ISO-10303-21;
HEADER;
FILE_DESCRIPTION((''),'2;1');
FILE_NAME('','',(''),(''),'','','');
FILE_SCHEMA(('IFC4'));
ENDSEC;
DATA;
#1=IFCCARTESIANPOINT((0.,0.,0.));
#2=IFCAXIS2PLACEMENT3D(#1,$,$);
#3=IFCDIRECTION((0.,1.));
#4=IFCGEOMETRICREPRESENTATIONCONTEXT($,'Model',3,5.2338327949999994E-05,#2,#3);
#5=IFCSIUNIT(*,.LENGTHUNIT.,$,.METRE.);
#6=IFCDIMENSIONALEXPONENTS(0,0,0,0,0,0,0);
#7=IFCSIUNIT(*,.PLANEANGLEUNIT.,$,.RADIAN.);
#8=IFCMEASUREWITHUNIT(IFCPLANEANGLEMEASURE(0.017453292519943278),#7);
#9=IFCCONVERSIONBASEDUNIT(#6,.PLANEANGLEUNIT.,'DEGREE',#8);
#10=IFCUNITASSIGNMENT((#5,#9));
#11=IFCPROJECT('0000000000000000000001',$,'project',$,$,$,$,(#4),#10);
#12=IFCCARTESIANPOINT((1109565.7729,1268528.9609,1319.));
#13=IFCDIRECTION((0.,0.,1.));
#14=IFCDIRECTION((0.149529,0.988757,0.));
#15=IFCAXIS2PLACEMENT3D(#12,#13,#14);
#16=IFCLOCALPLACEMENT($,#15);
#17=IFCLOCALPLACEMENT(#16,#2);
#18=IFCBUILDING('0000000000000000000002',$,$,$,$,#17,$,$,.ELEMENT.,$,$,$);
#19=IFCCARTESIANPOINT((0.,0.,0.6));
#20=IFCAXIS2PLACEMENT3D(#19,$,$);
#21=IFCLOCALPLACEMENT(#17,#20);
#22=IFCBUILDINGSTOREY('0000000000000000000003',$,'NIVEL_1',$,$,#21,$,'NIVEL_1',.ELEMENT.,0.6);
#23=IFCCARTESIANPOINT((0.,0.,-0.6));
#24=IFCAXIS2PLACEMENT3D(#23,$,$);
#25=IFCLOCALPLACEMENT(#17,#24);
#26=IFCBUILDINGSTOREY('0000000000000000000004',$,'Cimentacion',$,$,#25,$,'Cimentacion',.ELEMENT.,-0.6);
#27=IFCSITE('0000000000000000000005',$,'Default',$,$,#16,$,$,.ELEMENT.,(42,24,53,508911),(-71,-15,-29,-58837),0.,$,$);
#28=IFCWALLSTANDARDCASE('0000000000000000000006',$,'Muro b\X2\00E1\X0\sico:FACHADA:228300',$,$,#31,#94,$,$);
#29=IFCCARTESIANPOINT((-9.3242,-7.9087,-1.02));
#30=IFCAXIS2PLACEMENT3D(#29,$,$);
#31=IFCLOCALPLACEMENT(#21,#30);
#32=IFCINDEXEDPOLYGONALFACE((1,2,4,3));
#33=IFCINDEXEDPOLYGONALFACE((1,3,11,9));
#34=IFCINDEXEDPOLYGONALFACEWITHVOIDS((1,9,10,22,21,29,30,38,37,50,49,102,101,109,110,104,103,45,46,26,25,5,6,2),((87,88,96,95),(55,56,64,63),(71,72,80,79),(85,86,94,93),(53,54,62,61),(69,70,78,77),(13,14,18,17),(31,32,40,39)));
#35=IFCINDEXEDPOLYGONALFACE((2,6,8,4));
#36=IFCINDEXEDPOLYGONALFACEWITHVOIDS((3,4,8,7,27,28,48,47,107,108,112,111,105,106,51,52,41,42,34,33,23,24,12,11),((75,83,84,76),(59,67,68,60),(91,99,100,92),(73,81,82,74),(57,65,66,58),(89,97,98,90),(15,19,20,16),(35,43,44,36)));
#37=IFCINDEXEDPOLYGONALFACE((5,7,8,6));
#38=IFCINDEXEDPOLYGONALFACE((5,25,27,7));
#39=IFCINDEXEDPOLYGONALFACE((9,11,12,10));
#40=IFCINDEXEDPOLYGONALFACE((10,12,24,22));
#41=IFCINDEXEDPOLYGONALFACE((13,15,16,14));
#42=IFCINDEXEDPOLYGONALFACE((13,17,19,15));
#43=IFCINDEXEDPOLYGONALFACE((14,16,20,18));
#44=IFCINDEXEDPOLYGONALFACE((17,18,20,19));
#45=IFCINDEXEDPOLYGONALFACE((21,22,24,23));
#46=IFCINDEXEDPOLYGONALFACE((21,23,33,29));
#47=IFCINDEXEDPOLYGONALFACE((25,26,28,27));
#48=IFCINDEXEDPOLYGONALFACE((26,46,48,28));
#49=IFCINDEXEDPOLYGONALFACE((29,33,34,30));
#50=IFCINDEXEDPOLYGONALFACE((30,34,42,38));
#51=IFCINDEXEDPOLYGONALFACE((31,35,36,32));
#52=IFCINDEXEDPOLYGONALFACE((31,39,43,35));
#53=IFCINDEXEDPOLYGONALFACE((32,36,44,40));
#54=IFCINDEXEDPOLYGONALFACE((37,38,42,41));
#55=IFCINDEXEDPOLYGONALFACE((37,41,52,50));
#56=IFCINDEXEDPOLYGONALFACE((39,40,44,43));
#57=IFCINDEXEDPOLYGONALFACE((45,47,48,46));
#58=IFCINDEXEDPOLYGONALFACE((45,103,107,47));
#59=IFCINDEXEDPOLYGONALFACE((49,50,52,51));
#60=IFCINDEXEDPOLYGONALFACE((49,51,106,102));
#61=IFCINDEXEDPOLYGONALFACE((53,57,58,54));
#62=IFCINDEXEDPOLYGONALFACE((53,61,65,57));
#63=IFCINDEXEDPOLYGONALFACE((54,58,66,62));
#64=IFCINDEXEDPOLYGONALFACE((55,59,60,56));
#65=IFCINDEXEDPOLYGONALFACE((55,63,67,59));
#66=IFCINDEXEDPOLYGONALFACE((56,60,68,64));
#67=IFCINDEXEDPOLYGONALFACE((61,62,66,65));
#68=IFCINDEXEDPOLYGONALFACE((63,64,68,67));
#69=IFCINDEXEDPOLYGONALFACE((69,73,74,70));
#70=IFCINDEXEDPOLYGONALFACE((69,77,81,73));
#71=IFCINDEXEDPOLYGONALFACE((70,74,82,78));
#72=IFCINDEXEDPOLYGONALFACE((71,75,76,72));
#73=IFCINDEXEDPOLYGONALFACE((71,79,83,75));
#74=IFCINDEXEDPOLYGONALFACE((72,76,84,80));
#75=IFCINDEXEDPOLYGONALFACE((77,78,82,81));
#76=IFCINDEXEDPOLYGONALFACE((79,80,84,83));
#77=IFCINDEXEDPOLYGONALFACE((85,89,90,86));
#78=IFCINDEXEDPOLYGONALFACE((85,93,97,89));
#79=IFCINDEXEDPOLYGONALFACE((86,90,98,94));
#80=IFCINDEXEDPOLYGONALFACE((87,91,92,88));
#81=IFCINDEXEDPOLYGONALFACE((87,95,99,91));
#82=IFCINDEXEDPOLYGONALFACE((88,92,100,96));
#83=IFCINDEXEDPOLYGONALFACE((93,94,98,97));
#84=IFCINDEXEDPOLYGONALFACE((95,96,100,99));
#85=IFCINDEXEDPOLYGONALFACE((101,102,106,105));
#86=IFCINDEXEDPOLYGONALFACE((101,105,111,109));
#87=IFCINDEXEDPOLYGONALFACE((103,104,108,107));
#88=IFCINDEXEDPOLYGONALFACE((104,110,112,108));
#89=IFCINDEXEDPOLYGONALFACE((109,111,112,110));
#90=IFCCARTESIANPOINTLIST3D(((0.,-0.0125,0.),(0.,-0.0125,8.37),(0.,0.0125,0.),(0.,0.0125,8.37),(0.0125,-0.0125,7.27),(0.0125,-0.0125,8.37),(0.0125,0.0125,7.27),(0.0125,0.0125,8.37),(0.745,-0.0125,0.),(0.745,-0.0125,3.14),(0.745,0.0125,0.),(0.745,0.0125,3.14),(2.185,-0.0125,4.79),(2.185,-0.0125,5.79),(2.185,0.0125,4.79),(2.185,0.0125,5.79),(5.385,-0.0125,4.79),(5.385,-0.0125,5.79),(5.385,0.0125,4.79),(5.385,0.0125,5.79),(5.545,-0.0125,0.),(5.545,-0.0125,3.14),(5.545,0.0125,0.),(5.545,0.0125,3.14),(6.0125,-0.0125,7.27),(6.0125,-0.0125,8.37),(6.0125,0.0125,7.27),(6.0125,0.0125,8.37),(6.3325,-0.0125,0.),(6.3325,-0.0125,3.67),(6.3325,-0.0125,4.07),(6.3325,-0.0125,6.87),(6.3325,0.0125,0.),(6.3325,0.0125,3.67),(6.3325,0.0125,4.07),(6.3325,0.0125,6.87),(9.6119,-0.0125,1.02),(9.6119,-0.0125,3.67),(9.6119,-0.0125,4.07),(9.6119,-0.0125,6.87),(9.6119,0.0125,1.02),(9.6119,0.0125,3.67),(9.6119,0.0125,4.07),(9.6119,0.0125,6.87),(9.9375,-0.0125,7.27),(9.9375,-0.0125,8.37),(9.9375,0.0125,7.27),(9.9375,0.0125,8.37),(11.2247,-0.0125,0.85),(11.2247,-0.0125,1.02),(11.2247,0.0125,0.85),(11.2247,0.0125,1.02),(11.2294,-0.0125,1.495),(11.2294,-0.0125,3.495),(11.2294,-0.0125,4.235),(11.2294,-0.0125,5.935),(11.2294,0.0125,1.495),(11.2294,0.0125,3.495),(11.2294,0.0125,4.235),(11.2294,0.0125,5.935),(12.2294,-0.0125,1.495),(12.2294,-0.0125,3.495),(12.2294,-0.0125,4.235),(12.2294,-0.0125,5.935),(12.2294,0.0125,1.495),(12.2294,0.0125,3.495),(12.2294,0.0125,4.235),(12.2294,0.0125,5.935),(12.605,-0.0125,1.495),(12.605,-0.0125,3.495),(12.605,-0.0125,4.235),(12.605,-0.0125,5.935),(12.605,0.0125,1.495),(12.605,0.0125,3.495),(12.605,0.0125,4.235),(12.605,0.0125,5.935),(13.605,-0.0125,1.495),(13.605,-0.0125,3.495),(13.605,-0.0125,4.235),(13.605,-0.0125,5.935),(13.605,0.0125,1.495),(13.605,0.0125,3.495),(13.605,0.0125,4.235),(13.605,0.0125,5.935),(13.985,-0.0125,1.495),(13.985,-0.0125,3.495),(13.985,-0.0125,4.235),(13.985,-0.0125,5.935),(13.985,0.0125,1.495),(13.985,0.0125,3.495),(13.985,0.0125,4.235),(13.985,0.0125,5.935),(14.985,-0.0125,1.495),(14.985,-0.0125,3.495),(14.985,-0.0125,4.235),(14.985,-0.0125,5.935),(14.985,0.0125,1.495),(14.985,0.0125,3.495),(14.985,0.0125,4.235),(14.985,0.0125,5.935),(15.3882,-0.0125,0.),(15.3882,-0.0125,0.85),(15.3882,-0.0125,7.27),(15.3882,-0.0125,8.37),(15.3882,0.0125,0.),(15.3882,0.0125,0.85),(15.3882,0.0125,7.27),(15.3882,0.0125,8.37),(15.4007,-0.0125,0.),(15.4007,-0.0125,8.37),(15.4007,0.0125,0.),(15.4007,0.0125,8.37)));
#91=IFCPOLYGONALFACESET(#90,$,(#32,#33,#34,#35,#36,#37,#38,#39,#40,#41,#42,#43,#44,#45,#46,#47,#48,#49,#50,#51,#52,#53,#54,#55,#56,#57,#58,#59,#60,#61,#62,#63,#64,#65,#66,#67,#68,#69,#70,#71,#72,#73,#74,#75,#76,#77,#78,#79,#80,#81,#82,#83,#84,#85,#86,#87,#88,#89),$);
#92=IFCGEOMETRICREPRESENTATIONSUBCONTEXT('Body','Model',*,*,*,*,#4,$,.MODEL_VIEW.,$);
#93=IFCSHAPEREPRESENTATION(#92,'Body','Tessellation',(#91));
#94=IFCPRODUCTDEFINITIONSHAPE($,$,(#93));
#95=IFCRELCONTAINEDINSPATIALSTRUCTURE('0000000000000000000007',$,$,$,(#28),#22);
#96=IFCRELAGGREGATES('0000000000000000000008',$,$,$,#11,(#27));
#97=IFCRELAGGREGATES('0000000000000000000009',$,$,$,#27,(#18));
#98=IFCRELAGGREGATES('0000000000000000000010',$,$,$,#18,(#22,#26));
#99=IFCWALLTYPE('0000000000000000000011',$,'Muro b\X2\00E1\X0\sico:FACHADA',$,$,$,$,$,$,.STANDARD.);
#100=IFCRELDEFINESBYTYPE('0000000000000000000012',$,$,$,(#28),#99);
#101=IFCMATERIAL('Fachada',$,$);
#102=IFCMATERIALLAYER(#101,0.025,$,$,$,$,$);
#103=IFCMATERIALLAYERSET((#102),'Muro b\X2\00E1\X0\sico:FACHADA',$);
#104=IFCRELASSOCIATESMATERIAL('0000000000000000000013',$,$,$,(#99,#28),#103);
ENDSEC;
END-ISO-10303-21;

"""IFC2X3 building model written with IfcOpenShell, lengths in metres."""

from ifc_helpers import new_model, entity, si_unit, converted_unit, direction, frame, frame_2d, origin, origin_2d_with_axis, place, context, subcontext, project, spatial, polyline, rectangle, outline, extrude, material, layer, layer_set, layer_usage, type_object, element, save


model = new_model("IFC2X3")

# Units and contexts
model_context = context("Model", 3, precision=5.2338327949999994e-05, world=origin(), true_north=direction((0.0, 1.0)))
body_context = subcontext(model_context, "Body", "Model", "MODEL_VIEW")
ifc_project = project(units=[si_unit("LENGTHUNIT", "METRE"), converted_unit("PLANEANGLEUNIT", "DEGREE", entity("IfcPlaneAngleMeasure", 0.017453292519943278), si_unit("PLANEANGLEUNIT", "RADIAN"), dimensions=[0, 0, 0, 0, 0, 0, 0])], contexts=[model_context])

# Site, building, storey
site_placement = place(None, frame((1109565.7729, 1268528.9609, 1319.0), z_axis=(0.0, 0.0, 1.0), x_axis=(0.149529, 0.988757, 0.0)))
site = spatial("IfcSite", under=ifc_project, at=site_placement, Name="Default", CompositionType="ELEMENT", RefLatitude=(42, 24, 53, 508911), RefLongitude=(-71, -15, -29, -58837), RefElevation=0.0)
building_placement = place(site_placement, origin())
building = spatial("IfcBuilding", under=site, at=building_placement, CompositionType="ELEMENT")
storey_1_placement = place(building_placement, frame((0.0, 0.0, 0.6)))
storey_1 = spatial("IfcBuildingStorey", under=building, at=storey_1_placement, Name="NIVEL_1", LongName="NIVEL_1", CompositionType="ELEMENT", Elevation=0.6)

# Shared definitions
storey_2_placement = place(building_placement, frame((0.0, 0.0, -0.6)))
storey_2 = spatial("IfcBuildingStorey", under=building, at=storey_2_placement, Name="Cimentacion", LongName="Cimentacion", CompositionType="ELEMENT", Elevation=-0.6)

# Wall, openings
ifc_material_1 = material(Name="Fachada")
ifc_layer_1 = layer(ifc_material_1, 0.025)
ifc_layer_set_1 = layer_set([ifc_layer_1], Name="Muro básico:FACHADA")
ifc_layer_usage_1 = layer_usage(ifc_layer_set_1, "AXIS2", "POSITIVE", -0.0125)
wall_type_1 = type_object("IfcWallType", Name="Muro básico:FACHADA", PredefinedType="STANDARD", material=ifc_layer_set_1)
wall_1_placement = place(storey_1_placement, frame((-9.3242, -7.9087, -1.02)))
wall_1 = element("IfcWallStandardCase", 1, at=wall_1_placement, inside=storey_1, type_object=wall_type_1, material=ifc_layer_usage_1, Name="Muro básico:FACHADA:228300", context=body_context, shape_type="SweptSolid", body=[
    extrude(rectangle(XDim=15.4007, YDim=0.025, at=frame_2d((7.7004, 0.0), x_axis=(-1.0, 0.0))), origin(), (0.0, 0.0, 1.0), 8.37),
])
opening_1_placement = place(wall_1_placement, origin())
element("IfcOpeningElement", 2, at=opening_1_placement, cuts=wall_1, ObjectType="Opening", context=body_context, shape_type="SweptSolid", body=[
    extrude(rectangle(XDim=2.8, YDim=3.2794, at=frame_2d((0.0, 0.0), x_axis=(0.0, 1.0))), frame((7.9722, 0.0125, 5.47), z_axis=(0.0, -1.0, 0.0), x_axis=(-1.0, 0.0, 0.0)), (0.0, 0.0, 1.0), 0.025),
])
opening_2_placement = place(wall_1_placement, origin())
element("IfcOpeningElement", 3, at=opening_2_placement, cuts=wall_1, ObjectType="Opening", context=body_context, shape_type="SweptSolid", body=[
    extrude(rectangle(XDim=1.0, YDim=3.2, at=frame_2d((0.0, 0.0), x_axis=(0.0, 1.0))), frame((3.785, 0.0125, 5.29), z_axis=(0.0, -1.0, 0.0), x_axis=(-1.0, 0.0, 0.0)), (0.0, 0.0, 1.0), 0.025),
])
opening_3_placement = place(wall_1_placement, origin())
element("IfcOpeningElement", 4, at=opening_3_placement, cuts=wall_1, ObjectType="Opening", context=body_context, shape_type="SweptSolid", body=[
    extrude(rectangle(XDim=1.7, YDim=1.0, at=frame_2d((0.0, 0.0), x_axis=(0.0, 1.0))), frame((11.7294, 0.0125, 5.085), z_axis=(0.0, -1.0, 0.0), x_axis=(-1.0, 0.0, 0.0)), (0.0, 0.0, 1.0), 0.025),
])
opening_4_placement = place(wall_1_placement, origin())
element("IfcOpeningElement", 5, at=opening_4_placement, cuts=wall_1, ObjectType="Opening", context=body_context, shape_type="SweptSolid", body=[
    extrude(rectangle(XDim=1.7, YDim=1.0, at=origin_2d_with_axis()), frame((13.105, 0.0125, 5.085), z_axis=(0.0, -1.0, 0.0), x_axis=(0.0, 0.0, 1.0)), (0.0, 0.0, 1.0), 0.025),
])
opening_5_placement = place(wall_1_placement, origin())
element("IfcOpeningElement", 6, at=opening_5_placement, cuts=wall_1, ObjectType="Opening", context=body_context, shape_type="SweptSolid", body=[
    extrude(rectangle(XDim=1.7, YDim=1.0, at=origin_2d_with_axis()), frame((14.485, 0.0125, 5.085), z_axis=(0.0, -1.0, 0.0), x_axis=(0.0, 0.0, 1.0)), (0.0, 0.0, 1.0), 0.025),
])
opening_6_placement = place(wall_1_placement, origin())
element("IfcOpeningElement", 7, at=opening_6_placement, cuts=wall_1, ObjectType="Opening", context=body_context, shape_type="SweptSolid", body=[
    extrude(rectangle(XDim=2.0, YDim=1.0, at=origin_2d_with_axis()), frame((14.485, 0.0125, 2.495), z_axis=(0.0, -1.0, 0.0), x_axis=(0.0, 0.0, 1.0)), (0.0, 0.0, 1.0), 0.025),
])
opening_7_placement = place(wall_1_placement, origin())
element("IfcOpeningElement", 8, at=opening_7_placement, cuts=wall_1, ObjectType="Opening", context=body_context, shape_type="SweptSolid", body=[
    extrude(rectangle(XDim=2.0, YDim=1.0, at=origin_2d_with_axis()), frame((13.105, 0.0125, 2.495), z_axis=(0.0, -1.0, 0.0), x_axis=(0.0, 0.0, 1.0)), (0.0, 0.0, 1.0), 0.025),
])
opening_8_placement = place(wall_1_placement, origin())
element("IfcOpeningElement", 9, at=opening_8_placement, cuts=wall_1, ObjectType="Opening", context=body_context, shape_type="SweptSolid", body=[
    extrude(rectangle(XDim=2.0, YDim=1.0, at=frame_2d((0.0, 0.0), x_axis=(1.0, 0.0))), frame((11.7294, 0.0125, 2.495), z_axis=(0.0, -1.0, 0.0), x_axis=(0.0, 0.0, 1.0)), (0.0, 0.0, 1.0), 0.025),
])
opening_9_placement = place(wall_1_placement, origin())
element("IfcOpeningElement", 10, at=opening_9_placement, cuts=wall_1, ObjectType="Opening", context=body_context, shape_type="SweptSolid", body=[
    extrude(rectangle(XDim=3.14, YDim=4.8, at=frame_2d((0.0, 0.0), x_axis=(0.0, 1.0))), frame((3.145, 0.0125, 1.57), z_axis=(0.0, -1.0, 0.0), x_axis=(1.0, 0.0, 0.0)), (0.0, 0.0, 1.0), 0.025),
])
opening_10_placement = place(wall_1_placement, origin())
element("IfcOpeningElement", 11, at=opening_10_placement, cuts=wall_1, ObjectType="Opening", context=body_context, shape_type="SweptSolid", body=[
    extrude(outline(polyline([(-4.3068, -1.385), (4.7489, -1.385), (4.7489, -0.535), (0.5854, -0.535), (0.5854, -0.365), (-1.0274, -0.365), (-1.0274, 2.285), (-4.3068, 2.285), (-4.3068, -1.385)])), frame((10.6393, 0.0125, 1.385), z_axis=(0.0, -1.0, 0.0), x_axis=(1.0, 0.0, 0.0)), (0.0, 0.0, 1.0), 0.025),
])
opening_11_placement = place(wall_1_placement, origin())
element("IfcOpeningElement", 12, at=opening_11_placement, cuts=wall_1, ObjectType="Opening", context=body_context, shape_type="SweptSolid", body=[
    extrude(rectangle(XDim=1.1, YDim=5.4508, at=origin_2d_with_axis()), frame((12.6629, 0.0125, 7.82), z_axis=(0.0, -1.0, 0.0), x_axis=(0.0, 0.0, 1.0)), (0.0, 0.0, 1.0), 0.025),
])
opening_12_placement = place(wall_1_placement, origin())
element("IfcOpeningElement", 13, at=opening_12_placement, cuts=wall_1, ObjectType="Opening", context=body_context, shape_type="SweptSolid", body=[
    extrude(rectangle(XDim=1.1, YDim=6.0, at=frame_2d((0.0, 0.0), x_axis=(0.0, 1.0))), frame((3.0125, 0.0125, 7.82), z_axis=(0.0, -1.0, 0.0), x_axis=(-1.0, 0.0, 0.0)), (0.0, 0.0, 1.0), 0.025),
])

save(model, "model.ifc")
